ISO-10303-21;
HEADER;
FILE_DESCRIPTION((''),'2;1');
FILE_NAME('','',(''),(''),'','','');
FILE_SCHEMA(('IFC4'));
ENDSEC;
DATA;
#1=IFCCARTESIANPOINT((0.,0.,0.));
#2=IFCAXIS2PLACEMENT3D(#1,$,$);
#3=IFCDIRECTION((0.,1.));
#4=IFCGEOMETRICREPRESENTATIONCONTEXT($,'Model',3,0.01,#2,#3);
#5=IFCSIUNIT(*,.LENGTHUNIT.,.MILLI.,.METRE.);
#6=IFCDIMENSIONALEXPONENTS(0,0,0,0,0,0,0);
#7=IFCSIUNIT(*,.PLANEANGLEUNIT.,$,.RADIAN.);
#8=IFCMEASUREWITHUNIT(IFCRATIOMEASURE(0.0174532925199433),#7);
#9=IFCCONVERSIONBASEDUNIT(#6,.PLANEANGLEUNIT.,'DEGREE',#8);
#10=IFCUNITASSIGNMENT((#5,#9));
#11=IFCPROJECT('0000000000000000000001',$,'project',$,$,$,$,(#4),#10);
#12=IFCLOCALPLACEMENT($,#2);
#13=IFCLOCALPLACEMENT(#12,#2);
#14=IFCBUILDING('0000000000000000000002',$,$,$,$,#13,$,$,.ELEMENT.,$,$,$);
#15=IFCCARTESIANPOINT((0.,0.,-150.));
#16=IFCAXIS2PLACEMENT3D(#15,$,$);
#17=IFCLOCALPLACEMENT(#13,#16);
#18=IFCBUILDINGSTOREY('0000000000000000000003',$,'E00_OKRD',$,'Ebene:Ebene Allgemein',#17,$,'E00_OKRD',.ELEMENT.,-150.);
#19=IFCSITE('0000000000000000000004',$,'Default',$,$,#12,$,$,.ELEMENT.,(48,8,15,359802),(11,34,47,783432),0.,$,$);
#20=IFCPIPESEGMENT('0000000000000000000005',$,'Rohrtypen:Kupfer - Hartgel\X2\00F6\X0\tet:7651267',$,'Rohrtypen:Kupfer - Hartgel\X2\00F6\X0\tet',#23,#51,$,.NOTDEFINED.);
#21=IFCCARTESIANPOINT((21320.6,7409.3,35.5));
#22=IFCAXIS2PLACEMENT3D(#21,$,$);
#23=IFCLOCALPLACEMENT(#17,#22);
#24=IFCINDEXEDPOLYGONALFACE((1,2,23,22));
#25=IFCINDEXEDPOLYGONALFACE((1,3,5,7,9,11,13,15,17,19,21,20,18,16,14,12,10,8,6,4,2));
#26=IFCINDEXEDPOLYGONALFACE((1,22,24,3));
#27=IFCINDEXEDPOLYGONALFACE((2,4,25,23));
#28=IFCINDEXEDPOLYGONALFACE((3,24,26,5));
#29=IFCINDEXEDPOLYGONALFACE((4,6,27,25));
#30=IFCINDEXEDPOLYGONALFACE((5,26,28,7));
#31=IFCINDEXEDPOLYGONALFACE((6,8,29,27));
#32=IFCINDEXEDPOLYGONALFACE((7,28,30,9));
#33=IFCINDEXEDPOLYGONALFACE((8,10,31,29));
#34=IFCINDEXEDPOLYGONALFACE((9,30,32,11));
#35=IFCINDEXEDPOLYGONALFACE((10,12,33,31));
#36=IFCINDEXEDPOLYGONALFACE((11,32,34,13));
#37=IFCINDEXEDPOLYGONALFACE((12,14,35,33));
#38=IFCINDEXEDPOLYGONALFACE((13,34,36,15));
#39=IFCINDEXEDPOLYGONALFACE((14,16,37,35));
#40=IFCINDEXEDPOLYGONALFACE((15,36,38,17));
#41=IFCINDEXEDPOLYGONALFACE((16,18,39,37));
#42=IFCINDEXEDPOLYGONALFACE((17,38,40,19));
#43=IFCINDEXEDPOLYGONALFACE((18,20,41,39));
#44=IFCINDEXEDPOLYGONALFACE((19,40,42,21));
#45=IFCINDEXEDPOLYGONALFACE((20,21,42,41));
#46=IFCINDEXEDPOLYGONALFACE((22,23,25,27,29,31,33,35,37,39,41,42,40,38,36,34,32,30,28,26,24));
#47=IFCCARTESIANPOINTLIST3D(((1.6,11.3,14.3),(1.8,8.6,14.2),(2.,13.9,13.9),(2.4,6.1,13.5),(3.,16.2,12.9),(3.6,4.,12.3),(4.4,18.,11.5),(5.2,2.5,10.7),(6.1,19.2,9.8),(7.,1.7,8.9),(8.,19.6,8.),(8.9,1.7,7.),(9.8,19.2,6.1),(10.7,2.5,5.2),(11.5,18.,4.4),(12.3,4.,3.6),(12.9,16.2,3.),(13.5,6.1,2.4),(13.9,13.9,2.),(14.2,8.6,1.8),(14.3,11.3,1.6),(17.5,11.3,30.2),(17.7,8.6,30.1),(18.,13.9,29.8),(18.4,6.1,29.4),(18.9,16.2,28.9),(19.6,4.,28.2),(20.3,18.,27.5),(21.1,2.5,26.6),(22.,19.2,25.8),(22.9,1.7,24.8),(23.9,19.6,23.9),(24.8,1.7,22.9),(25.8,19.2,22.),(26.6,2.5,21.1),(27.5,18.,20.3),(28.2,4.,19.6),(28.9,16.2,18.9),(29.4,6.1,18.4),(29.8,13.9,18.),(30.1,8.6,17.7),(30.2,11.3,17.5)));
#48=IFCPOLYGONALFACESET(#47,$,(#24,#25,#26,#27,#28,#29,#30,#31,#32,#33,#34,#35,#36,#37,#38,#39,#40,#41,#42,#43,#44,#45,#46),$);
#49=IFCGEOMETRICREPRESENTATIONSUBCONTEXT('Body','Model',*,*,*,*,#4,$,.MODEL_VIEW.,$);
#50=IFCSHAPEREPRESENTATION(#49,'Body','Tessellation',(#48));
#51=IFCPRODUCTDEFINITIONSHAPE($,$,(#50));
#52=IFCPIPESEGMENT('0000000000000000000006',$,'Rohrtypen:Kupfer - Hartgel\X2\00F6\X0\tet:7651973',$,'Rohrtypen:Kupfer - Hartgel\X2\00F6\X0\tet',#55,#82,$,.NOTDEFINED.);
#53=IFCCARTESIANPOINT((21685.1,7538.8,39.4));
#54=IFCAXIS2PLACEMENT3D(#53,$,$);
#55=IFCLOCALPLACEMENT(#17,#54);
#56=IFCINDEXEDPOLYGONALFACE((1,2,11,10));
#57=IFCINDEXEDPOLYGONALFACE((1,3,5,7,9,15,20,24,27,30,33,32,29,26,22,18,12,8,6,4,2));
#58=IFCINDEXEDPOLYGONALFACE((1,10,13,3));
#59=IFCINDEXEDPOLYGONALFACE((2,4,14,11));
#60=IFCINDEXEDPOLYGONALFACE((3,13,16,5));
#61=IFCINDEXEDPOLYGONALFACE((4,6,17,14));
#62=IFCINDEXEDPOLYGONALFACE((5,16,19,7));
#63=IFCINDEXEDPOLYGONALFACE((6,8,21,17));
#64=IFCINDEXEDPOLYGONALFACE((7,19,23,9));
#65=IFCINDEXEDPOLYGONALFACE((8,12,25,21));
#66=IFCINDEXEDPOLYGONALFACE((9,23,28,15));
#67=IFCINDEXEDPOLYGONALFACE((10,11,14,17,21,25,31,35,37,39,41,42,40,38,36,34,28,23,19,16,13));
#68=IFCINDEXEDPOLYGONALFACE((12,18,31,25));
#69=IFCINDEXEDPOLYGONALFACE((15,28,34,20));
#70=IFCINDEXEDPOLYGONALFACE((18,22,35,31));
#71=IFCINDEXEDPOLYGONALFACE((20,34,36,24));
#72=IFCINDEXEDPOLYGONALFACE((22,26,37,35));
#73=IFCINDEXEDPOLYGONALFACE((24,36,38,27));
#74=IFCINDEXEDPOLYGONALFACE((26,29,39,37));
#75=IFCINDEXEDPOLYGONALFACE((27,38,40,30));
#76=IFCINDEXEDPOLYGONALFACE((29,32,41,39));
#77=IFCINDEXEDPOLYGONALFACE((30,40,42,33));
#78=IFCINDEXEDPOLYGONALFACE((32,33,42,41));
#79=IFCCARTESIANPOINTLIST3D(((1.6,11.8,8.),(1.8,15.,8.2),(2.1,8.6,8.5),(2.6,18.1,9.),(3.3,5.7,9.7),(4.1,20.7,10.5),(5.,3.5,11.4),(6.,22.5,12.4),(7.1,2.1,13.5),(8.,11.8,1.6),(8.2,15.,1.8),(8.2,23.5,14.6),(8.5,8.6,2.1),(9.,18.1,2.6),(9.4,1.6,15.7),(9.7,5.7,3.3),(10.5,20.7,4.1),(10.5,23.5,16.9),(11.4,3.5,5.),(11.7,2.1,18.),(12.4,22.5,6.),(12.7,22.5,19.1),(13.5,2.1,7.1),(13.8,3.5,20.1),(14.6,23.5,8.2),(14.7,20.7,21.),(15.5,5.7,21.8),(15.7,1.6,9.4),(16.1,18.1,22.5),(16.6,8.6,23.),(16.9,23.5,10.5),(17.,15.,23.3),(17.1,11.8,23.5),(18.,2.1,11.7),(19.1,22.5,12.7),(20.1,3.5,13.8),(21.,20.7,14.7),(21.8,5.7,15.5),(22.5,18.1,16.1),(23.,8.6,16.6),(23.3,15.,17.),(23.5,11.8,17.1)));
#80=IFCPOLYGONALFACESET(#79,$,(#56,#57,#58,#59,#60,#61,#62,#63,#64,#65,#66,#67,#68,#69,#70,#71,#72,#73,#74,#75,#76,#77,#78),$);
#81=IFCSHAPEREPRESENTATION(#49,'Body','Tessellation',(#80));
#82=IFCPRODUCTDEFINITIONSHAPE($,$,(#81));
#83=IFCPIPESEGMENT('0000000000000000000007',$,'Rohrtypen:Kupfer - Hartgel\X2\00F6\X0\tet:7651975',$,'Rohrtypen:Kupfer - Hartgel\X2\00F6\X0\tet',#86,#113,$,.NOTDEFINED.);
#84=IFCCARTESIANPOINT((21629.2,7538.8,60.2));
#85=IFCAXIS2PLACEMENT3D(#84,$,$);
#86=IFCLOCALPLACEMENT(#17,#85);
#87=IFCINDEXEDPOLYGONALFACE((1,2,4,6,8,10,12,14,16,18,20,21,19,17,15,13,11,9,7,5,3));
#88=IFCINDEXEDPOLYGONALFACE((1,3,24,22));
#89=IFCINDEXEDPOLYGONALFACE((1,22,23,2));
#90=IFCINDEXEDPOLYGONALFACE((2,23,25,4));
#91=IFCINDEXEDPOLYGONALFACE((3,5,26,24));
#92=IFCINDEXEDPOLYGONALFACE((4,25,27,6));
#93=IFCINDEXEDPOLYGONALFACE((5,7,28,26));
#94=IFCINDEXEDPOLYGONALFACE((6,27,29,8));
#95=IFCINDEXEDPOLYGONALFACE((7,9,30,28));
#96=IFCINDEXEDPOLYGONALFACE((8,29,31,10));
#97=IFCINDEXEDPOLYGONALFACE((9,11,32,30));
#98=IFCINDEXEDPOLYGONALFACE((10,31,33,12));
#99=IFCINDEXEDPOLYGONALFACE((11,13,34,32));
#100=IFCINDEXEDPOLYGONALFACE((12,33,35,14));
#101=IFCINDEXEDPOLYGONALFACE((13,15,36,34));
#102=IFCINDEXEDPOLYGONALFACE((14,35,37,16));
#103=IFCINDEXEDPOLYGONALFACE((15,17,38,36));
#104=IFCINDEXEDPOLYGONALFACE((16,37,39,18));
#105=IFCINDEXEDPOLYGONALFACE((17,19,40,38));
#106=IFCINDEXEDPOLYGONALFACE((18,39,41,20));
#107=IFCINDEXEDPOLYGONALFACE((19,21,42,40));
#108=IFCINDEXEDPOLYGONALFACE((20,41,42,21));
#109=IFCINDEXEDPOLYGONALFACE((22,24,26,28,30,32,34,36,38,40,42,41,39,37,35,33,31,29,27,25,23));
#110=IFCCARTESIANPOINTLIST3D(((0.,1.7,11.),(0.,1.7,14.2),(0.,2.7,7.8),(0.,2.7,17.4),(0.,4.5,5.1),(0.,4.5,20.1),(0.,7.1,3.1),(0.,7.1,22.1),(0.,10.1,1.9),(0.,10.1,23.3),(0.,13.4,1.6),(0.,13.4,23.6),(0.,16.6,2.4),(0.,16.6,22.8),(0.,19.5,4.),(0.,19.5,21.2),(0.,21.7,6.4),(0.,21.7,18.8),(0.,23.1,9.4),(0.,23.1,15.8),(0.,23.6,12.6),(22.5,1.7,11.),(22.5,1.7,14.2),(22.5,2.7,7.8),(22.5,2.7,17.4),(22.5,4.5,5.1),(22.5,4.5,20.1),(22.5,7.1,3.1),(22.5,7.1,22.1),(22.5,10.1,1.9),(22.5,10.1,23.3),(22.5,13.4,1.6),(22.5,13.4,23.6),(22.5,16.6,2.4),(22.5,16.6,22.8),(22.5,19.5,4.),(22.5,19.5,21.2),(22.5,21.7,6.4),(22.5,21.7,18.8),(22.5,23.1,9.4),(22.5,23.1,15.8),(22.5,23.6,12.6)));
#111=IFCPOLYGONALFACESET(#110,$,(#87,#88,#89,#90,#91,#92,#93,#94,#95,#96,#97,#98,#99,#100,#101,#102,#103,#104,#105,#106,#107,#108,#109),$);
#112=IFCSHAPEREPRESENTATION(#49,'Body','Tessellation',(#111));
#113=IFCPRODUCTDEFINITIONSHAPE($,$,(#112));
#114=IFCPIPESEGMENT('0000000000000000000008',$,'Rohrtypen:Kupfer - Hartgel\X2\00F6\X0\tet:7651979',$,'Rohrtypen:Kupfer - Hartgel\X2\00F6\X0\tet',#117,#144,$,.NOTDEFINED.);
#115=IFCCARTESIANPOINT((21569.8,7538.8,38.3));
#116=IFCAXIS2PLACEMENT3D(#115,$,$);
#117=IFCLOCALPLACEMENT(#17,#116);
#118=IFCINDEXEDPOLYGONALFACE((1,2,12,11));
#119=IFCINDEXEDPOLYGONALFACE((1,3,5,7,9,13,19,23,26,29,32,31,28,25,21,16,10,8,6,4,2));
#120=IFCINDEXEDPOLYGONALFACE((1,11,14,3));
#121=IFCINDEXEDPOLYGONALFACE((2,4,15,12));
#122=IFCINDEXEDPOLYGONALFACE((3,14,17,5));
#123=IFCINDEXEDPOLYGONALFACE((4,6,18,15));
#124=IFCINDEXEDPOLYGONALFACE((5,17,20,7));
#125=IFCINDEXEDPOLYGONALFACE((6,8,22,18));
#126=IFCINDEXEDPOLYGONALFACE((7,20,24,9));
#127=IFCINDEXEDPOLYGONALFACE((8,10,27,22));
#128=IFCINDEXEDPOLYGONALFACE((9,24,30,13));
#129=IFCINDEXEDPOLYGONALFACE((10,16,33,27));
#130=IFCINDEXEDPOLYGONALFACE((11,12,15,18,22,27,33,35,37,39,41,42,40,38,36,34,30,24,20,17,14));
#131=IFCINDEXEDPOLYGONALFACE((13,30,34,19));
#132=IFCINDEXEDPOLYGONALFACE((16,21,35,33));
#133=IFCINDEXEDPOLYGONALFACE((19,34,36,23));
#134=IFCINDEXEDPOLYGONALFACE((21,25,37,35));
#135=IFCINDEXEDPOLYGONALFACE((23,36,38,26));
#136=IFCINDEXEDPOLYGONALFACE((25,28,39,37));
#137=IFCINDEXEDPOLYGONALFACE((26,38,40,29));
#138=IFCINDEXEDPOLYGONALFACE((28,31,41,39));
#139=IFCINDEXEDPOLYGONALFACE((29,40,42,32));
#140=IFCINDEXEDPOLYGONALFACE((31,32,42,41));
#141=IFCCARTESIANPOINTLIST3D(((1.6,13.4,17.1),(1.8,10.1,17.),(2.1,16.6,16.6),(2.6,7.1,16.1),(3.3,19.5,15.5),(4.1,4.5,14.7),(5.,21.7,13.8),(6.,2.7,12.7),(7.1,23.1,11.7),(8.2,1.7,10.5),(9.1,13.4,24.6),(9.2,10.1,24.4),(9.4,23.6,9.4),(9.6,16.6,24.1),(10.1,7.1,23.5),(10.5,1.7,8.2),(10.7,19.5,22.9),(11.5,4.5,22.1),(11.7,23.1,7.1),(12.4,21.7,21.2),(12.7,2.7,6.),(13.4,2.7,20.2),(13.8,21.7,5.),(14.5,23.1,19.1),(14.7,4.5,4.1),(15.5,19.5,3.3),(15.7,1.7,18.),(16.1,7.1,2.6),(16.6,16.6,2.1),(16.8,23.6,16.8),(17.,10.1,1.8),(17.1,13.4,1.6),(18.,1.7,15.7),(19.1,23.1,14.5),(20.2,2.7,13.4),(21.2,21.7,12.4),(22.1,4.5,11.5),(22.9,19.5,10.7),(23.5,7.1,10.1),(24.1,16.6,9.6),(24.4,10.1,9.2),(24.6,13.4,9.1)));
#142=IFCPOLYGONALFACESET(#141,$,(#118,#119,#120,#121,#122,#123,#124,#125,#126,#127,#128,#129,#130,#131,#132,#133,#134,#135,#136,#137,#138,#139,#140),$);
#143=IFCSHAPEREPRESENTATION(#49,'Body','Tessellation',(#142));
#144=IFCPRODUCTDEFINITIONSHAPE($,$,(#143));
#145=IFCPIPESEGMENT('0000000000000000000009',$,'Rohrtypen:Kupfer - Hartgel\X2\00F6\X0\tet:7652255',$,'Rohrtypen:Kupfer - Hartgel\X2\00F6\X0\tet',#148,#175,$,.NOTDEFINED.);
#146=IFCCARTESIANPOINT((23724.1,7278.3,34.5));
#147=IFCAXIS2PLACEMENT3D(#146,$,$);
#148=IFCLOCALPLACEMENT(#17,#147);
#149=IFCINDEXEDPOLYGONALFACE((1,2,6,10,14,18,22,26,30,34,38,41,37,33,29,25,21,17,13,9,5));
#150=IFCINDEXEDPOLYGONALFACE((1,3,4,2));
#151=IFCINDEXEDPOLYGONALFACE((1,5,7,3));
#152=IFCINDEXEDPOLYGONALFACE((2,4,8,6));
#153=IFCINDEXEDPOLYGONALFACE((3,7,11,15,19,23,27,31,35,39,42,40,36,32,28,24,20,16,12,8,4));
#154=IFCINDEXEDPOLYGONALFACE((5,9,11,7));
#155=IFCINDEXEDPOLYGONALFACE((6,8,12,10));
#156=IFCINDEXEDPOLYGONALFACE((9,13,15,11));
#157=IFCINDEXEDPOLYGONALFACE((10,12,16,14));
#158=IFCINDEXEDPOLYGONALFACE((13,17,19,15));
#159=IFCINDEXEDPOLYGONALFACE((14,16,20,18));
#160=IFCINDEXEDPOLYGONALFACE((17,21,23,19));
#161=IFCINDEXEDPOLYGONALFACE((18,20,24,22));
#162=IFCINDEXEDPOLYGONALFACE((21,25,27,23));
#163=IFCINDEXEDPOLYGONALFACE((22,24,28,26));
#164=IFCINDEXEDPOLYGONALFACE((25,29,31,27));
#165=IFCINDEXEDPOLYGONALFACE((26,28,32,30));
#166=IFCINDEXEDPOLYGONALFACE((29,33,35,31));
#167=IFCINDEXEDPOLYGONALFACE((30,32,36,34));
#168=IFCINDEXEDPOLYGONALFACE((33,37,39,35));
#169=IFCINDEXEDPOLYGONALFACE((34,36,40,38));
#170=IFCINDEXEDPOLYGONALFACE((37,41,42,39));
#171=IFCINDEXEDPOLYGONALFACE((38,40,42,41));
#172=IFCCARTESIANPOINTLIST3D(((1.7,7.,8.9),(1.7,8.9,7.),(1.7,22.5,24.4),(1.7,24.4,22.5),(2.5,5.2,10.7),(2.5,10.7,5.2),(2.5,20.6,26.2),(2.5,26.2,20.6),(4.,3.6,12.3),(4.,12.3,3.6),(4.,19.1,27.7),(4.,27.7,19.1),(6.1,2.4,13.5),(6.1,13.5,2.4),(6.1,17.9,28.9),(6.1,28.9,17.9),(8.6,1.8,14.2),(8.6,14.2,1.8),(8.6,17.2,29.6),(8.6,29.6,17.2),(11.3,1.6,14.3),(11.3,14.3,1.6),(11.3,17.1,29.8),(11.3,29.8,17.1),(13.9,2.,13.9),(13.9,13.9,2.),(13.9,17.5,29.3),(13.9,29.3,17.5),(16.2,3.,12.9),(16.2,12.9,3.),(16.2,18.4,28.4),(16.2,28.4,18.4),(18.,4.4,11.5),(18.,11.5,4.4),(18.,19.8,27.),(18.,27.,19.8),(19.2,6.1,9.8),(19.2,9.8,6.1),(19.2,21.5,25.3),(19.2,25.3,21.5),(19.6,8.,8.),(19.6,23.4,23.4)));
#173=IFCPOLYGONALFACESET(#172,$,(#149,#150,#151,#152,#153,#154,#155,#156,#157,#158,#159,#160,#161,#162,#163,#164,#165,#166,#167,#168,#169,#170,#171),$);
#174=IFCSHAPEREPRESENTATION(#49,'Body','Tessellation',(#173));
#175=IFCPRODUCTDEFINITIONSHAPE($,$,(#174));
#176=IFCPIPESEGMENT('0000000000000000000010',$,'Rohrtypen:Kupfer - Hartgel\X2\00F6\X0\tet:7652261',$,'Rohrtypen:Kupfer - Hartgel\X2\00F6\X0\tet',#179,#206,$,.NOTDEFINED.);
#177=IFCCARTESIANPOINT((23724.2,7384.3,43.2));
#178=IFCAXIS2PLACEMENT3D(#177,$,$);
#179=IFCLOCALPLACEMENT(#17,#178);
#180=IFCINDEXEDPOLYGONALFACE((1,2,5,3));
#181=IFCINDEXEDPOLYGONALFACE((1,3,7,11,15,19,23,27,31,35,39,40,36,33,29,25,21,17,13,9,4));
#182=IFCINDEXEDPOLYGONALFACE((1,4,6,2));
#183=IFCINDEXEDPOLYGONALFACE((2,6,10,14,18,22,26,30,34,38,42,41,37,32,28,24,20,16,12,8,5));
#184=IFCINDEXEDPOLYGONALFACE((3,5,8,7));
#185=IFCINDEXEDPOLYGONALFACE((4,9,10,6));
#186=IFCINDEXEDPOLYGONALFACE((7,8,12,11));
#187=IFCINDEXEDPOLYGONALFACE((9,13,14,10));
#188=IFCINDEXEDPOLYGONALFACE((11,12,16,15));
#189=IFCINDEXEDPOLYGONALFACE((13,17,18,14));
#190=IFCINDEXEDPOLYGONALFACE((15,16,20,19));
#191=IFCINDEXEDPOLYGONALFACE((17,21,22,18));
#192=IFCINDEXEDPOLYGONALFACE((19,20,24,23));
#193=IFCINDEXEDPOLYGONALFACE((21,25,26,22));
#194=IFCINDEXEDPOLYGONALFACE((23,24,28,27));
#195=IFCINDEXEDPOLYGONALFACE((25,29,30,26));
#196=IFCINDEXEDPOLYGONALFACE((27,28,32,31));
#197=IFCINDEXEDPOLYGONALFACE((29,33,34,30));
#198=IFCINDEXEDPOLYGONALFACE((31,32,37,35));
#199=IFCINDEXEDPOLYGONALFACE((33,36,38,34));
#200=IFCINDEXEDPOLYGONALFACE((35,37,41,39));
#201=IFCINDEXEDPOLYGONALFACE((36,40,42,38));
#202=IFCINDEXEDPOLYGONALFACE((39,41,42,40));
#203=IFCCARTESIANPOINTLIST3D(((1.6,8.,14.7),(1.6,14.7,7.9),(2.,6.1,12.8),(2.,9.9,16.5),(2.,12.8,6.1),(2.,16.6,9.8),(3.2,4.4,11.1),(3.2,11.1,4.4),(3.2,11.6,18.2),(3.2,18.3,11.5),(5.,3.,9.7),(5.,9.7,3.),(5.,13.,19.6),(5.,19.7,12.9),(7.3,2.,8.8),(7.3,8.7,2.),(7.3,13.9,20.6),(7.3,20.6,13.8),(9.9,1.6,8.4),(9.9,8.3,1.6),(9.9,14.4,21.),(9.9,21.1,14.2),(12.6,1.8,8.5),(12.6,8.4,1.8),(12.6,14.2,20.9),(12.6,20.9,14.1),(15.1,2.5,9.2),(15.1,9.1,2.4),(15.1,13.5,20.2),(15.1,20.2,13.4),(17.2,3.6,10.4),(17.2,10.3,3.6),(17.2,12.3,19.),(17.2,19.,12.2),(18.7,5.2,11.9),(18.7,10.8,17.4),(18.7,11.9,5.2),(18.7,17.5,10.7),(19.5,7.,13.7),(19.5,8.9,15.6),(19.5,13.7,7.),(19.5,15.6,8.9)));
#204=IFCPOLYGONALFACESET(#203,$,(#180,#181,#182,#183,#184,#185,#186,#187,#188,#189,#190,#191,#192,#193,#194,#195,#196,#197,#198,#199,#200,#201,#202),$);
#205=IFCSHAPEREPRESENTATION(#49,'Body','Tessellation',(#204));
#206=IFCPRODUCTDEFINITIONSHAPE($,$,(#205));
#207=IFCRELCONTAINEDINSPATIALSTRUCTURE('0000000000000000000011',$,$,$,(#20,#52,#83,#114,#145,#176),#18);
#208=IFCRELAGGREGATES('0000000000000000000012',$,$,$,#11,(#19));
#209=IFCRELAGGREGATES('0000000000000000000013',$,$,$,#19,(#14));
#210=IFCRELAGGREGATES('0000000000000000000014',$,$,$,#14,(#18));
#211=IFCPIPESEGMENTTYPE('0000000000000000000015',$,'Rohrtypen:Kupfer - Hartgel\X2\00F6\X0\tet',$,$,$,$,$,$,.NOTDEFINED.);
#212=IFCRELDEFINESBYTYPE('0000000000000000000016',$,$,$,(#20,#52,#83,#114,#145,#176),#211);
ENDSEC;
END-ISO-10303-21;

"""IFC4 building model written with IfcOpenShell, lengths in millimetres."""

from ifc_helpers import new_model, entity, si_unit, converted_unit, direction, frame, frame_2d, origin, origin_2d_with_axis, place, context, subcontext, project, spatial, circle, extrude, type_object, element, save


model = new_model("IFC4")

# Units and contexts
model_context = context("Model", 3, precision=0.01, world=origin(), true_north=direction((0.0, 1.0)))
body_context = subcontext(model_context, "Body", "Model", "MODEL_VIEW")
ifc_project = project(units=[si_unit("LENGTHUNIT", "METRE", prefix="MILLI"), converted_unit("PLANEANGLEUNIT", "DEGREE", entity("IfcRatioMeasure", 0.0174532925199433), si_unit("PLANEANGLEUNIT", "RADIAN"), dimensions=[0, 0, 0, 0, 0, 0, 0])], contexts=[model_context])

# Site, building, storey
site_placement = place(None, origin())
site = spatial("IfcSite", under=ifc_project, at=site_placement, Name="Default", CompositionType="ELEMENT", RefLatitude=(48, 8, 15, 359802), RefLongitude=(11, 34, 47, 783432), RefElevation=0.0)
building_placement = place(site_placement, origin())
building = spatial("IfcBuilding", under=site, at=building_placement, CompositionType="ELEMENT")
storey_placement = place(building_placement, frame((0.0, 0.0, -150.0)))
storey = spatial("IfcBuildingStorey", under=building, at=storey_placement, Name="E00_OKRD", ObjectType="Ebene:Ebene Allgemein", LongName="E00_OKRD", CompositionType="ELEMENT", Elevation=-150.0)

# Pipe segments
pipe_segment_type = type_object("IfcPipeSegmentType", Name="Rohrtypen:Kupfer - Hartgelötet", PredefinedType="NOTDEFINED")
pipe_segment_1_placement = place(storey_placement, frame((21320.6, 7409.3, 35.5)))
element("IfcPipeSegment", 1, at=pipe_segment_1_placement, inside=storey, type_object=pipe_segment_type, Name="Rohrtypen:Kupfer - Hartgelötet:7651267", ObjectType="Rohrtypen:Kupfer - Hartgelötet", PredefinedType="NOTDEFINED", context=body_context, shape_type="SweptSolid", body=[
    extrude(circle(Radius=9.0, at=origin_2d_with_axis()), frame((8.0, 10.6, 8.0), z_axis=(0.707107, 0.0, 0.707107), x_axis=(0.0, 1.0, 0.0)), (0.0, 0.0, 1.0), 22.5),
])
pipe_segment_2_placement = place(storey_placement, frame((21685.1, 7538.8, 39.4)))
element("IfcPipeSegment", 2, at=pipe_segment_2_placement, inside=storey, type_object=pipe_segment_type, Name="Rohrtypen:Kupfer - Hartgelötet:7651973", ObjectType="Rohrtypen:Kupfer - Hartgelötet", PredefinedType="NOTDEFINED", context=body_context, shape_type="SweptSolid", body=[
    extrude(circle(Radius=11.0, at=origin_2d_with_axis()), frame((15.7, 12.6, 9.4), z_axis=(-0.707107, 0.0, 0.707107), x_axis=(0.0, -1.0, 0.0)), (0.0, 0.0, 1.0), 9.0),
])
pipe_segment_3_placement = place(storey_placement, frame((21629.2, 7538.8, 60.2)))
element("IfcPipeSegment", 3, at=pipe_segment_3_placement, inside=storey, type_object=pipe_segment_type, Name="Rohrtypen:Kupfer - Hartgelötet:7651975", ObjectType="Rohrtypen:Kupfer - Hartgelötet", PredefinedType="NOTDEFINED", context=body_context, shape_type="SweptSolid", body=[
    extrude(circle(Radius=11.0, at=origin_2d_with_axis()), frame((0.0, 12.6, 12.6), z_axis=(1.0, 0.0, 0.0), x_axis=(0.0, 1.0, 0.0)), (0.0, 0.0, 1.0), 22.5),
])
pipe_segment_4_placement = place(storey_placement, frame((21569.8, 7538.8, 38.3)))
element("IfcPipeSegment", 4, at=pipe_segment_4_placement, inside=storey, type_object=pipe_segment_type, Name="Rohrtypen:Kupfer - Hartgelötet:7651979", ObjectType="Rohrtypen:Kupfer - Hartgelötet", PredefinedType="NOTDEFINED", context=body_context, shape_type="SweptSolid", body=[
    extrude(circle(Radius=11.0, at=origin_2d_with_axis()), frame((9.4, 12.6, 9.4), z_axis=(0.707107, 0.0, 0.707107), x_axis=(0.0, 1.0, 0.0)), (0.0, 0.0, 1.0), 10.5),
])
pipe_segment_5_placement = place(storey_placement, frame((23724.1, 7278.3, 34.5)))
element("IfcPipeSegment", 5, at=pipe_segment_5_placement, inside=storey, type_object=pipe_segment_type, Name="Rohrtypen:Kupfer - Hartgelötet:7652255", ObjectType="Rohrtypen:Kupfer - Hartgelötet", PredefinedType="NOTDEFINED", context=body_context, shape_type="SweptSolid", body=[
    extrude(circle(Radius=9.0, at=frame_2d((0.0, 0.0), x_axis=(1.0, 0.0))), frame((10.6, 8.0, 8.0), z_axis=(0.0, 0.707107, 0.707107), x_axis=(1.0, 0.0, 0.0)), (0.0, 0.0, 1.0), 21.8),
])
pipe_segment_6_placement = place(storey_placement, frame((23724.2, 7384.3, 43.2)))
element("IfcPipeSegment", 6, at=pipe_segment_6_placement, inside=storey, type_object=pipe_segment_type, Name="Rohrtypen:Kupfer - Hartgelötet:7652261", ObjectType="Rohrtypen:Kupfer - Hartgelötet", PredefinedType="NOTDEFINED", context=body_context, shape_type="SweptSolid", body=[
    extrude(circle(Radius=9.0, at=frame_2d((0.0, 0.0), x_axis=(1.0, 0.0))), frame((10.6, 14.7, 7.9), z_axis=(0.0, -0.703461, 0.710734), x_axis=(-1.0, 0.0, 0.0)), (0.0, 0.0, 1.0), 9.5),
])

save(model, "model.ifc")
